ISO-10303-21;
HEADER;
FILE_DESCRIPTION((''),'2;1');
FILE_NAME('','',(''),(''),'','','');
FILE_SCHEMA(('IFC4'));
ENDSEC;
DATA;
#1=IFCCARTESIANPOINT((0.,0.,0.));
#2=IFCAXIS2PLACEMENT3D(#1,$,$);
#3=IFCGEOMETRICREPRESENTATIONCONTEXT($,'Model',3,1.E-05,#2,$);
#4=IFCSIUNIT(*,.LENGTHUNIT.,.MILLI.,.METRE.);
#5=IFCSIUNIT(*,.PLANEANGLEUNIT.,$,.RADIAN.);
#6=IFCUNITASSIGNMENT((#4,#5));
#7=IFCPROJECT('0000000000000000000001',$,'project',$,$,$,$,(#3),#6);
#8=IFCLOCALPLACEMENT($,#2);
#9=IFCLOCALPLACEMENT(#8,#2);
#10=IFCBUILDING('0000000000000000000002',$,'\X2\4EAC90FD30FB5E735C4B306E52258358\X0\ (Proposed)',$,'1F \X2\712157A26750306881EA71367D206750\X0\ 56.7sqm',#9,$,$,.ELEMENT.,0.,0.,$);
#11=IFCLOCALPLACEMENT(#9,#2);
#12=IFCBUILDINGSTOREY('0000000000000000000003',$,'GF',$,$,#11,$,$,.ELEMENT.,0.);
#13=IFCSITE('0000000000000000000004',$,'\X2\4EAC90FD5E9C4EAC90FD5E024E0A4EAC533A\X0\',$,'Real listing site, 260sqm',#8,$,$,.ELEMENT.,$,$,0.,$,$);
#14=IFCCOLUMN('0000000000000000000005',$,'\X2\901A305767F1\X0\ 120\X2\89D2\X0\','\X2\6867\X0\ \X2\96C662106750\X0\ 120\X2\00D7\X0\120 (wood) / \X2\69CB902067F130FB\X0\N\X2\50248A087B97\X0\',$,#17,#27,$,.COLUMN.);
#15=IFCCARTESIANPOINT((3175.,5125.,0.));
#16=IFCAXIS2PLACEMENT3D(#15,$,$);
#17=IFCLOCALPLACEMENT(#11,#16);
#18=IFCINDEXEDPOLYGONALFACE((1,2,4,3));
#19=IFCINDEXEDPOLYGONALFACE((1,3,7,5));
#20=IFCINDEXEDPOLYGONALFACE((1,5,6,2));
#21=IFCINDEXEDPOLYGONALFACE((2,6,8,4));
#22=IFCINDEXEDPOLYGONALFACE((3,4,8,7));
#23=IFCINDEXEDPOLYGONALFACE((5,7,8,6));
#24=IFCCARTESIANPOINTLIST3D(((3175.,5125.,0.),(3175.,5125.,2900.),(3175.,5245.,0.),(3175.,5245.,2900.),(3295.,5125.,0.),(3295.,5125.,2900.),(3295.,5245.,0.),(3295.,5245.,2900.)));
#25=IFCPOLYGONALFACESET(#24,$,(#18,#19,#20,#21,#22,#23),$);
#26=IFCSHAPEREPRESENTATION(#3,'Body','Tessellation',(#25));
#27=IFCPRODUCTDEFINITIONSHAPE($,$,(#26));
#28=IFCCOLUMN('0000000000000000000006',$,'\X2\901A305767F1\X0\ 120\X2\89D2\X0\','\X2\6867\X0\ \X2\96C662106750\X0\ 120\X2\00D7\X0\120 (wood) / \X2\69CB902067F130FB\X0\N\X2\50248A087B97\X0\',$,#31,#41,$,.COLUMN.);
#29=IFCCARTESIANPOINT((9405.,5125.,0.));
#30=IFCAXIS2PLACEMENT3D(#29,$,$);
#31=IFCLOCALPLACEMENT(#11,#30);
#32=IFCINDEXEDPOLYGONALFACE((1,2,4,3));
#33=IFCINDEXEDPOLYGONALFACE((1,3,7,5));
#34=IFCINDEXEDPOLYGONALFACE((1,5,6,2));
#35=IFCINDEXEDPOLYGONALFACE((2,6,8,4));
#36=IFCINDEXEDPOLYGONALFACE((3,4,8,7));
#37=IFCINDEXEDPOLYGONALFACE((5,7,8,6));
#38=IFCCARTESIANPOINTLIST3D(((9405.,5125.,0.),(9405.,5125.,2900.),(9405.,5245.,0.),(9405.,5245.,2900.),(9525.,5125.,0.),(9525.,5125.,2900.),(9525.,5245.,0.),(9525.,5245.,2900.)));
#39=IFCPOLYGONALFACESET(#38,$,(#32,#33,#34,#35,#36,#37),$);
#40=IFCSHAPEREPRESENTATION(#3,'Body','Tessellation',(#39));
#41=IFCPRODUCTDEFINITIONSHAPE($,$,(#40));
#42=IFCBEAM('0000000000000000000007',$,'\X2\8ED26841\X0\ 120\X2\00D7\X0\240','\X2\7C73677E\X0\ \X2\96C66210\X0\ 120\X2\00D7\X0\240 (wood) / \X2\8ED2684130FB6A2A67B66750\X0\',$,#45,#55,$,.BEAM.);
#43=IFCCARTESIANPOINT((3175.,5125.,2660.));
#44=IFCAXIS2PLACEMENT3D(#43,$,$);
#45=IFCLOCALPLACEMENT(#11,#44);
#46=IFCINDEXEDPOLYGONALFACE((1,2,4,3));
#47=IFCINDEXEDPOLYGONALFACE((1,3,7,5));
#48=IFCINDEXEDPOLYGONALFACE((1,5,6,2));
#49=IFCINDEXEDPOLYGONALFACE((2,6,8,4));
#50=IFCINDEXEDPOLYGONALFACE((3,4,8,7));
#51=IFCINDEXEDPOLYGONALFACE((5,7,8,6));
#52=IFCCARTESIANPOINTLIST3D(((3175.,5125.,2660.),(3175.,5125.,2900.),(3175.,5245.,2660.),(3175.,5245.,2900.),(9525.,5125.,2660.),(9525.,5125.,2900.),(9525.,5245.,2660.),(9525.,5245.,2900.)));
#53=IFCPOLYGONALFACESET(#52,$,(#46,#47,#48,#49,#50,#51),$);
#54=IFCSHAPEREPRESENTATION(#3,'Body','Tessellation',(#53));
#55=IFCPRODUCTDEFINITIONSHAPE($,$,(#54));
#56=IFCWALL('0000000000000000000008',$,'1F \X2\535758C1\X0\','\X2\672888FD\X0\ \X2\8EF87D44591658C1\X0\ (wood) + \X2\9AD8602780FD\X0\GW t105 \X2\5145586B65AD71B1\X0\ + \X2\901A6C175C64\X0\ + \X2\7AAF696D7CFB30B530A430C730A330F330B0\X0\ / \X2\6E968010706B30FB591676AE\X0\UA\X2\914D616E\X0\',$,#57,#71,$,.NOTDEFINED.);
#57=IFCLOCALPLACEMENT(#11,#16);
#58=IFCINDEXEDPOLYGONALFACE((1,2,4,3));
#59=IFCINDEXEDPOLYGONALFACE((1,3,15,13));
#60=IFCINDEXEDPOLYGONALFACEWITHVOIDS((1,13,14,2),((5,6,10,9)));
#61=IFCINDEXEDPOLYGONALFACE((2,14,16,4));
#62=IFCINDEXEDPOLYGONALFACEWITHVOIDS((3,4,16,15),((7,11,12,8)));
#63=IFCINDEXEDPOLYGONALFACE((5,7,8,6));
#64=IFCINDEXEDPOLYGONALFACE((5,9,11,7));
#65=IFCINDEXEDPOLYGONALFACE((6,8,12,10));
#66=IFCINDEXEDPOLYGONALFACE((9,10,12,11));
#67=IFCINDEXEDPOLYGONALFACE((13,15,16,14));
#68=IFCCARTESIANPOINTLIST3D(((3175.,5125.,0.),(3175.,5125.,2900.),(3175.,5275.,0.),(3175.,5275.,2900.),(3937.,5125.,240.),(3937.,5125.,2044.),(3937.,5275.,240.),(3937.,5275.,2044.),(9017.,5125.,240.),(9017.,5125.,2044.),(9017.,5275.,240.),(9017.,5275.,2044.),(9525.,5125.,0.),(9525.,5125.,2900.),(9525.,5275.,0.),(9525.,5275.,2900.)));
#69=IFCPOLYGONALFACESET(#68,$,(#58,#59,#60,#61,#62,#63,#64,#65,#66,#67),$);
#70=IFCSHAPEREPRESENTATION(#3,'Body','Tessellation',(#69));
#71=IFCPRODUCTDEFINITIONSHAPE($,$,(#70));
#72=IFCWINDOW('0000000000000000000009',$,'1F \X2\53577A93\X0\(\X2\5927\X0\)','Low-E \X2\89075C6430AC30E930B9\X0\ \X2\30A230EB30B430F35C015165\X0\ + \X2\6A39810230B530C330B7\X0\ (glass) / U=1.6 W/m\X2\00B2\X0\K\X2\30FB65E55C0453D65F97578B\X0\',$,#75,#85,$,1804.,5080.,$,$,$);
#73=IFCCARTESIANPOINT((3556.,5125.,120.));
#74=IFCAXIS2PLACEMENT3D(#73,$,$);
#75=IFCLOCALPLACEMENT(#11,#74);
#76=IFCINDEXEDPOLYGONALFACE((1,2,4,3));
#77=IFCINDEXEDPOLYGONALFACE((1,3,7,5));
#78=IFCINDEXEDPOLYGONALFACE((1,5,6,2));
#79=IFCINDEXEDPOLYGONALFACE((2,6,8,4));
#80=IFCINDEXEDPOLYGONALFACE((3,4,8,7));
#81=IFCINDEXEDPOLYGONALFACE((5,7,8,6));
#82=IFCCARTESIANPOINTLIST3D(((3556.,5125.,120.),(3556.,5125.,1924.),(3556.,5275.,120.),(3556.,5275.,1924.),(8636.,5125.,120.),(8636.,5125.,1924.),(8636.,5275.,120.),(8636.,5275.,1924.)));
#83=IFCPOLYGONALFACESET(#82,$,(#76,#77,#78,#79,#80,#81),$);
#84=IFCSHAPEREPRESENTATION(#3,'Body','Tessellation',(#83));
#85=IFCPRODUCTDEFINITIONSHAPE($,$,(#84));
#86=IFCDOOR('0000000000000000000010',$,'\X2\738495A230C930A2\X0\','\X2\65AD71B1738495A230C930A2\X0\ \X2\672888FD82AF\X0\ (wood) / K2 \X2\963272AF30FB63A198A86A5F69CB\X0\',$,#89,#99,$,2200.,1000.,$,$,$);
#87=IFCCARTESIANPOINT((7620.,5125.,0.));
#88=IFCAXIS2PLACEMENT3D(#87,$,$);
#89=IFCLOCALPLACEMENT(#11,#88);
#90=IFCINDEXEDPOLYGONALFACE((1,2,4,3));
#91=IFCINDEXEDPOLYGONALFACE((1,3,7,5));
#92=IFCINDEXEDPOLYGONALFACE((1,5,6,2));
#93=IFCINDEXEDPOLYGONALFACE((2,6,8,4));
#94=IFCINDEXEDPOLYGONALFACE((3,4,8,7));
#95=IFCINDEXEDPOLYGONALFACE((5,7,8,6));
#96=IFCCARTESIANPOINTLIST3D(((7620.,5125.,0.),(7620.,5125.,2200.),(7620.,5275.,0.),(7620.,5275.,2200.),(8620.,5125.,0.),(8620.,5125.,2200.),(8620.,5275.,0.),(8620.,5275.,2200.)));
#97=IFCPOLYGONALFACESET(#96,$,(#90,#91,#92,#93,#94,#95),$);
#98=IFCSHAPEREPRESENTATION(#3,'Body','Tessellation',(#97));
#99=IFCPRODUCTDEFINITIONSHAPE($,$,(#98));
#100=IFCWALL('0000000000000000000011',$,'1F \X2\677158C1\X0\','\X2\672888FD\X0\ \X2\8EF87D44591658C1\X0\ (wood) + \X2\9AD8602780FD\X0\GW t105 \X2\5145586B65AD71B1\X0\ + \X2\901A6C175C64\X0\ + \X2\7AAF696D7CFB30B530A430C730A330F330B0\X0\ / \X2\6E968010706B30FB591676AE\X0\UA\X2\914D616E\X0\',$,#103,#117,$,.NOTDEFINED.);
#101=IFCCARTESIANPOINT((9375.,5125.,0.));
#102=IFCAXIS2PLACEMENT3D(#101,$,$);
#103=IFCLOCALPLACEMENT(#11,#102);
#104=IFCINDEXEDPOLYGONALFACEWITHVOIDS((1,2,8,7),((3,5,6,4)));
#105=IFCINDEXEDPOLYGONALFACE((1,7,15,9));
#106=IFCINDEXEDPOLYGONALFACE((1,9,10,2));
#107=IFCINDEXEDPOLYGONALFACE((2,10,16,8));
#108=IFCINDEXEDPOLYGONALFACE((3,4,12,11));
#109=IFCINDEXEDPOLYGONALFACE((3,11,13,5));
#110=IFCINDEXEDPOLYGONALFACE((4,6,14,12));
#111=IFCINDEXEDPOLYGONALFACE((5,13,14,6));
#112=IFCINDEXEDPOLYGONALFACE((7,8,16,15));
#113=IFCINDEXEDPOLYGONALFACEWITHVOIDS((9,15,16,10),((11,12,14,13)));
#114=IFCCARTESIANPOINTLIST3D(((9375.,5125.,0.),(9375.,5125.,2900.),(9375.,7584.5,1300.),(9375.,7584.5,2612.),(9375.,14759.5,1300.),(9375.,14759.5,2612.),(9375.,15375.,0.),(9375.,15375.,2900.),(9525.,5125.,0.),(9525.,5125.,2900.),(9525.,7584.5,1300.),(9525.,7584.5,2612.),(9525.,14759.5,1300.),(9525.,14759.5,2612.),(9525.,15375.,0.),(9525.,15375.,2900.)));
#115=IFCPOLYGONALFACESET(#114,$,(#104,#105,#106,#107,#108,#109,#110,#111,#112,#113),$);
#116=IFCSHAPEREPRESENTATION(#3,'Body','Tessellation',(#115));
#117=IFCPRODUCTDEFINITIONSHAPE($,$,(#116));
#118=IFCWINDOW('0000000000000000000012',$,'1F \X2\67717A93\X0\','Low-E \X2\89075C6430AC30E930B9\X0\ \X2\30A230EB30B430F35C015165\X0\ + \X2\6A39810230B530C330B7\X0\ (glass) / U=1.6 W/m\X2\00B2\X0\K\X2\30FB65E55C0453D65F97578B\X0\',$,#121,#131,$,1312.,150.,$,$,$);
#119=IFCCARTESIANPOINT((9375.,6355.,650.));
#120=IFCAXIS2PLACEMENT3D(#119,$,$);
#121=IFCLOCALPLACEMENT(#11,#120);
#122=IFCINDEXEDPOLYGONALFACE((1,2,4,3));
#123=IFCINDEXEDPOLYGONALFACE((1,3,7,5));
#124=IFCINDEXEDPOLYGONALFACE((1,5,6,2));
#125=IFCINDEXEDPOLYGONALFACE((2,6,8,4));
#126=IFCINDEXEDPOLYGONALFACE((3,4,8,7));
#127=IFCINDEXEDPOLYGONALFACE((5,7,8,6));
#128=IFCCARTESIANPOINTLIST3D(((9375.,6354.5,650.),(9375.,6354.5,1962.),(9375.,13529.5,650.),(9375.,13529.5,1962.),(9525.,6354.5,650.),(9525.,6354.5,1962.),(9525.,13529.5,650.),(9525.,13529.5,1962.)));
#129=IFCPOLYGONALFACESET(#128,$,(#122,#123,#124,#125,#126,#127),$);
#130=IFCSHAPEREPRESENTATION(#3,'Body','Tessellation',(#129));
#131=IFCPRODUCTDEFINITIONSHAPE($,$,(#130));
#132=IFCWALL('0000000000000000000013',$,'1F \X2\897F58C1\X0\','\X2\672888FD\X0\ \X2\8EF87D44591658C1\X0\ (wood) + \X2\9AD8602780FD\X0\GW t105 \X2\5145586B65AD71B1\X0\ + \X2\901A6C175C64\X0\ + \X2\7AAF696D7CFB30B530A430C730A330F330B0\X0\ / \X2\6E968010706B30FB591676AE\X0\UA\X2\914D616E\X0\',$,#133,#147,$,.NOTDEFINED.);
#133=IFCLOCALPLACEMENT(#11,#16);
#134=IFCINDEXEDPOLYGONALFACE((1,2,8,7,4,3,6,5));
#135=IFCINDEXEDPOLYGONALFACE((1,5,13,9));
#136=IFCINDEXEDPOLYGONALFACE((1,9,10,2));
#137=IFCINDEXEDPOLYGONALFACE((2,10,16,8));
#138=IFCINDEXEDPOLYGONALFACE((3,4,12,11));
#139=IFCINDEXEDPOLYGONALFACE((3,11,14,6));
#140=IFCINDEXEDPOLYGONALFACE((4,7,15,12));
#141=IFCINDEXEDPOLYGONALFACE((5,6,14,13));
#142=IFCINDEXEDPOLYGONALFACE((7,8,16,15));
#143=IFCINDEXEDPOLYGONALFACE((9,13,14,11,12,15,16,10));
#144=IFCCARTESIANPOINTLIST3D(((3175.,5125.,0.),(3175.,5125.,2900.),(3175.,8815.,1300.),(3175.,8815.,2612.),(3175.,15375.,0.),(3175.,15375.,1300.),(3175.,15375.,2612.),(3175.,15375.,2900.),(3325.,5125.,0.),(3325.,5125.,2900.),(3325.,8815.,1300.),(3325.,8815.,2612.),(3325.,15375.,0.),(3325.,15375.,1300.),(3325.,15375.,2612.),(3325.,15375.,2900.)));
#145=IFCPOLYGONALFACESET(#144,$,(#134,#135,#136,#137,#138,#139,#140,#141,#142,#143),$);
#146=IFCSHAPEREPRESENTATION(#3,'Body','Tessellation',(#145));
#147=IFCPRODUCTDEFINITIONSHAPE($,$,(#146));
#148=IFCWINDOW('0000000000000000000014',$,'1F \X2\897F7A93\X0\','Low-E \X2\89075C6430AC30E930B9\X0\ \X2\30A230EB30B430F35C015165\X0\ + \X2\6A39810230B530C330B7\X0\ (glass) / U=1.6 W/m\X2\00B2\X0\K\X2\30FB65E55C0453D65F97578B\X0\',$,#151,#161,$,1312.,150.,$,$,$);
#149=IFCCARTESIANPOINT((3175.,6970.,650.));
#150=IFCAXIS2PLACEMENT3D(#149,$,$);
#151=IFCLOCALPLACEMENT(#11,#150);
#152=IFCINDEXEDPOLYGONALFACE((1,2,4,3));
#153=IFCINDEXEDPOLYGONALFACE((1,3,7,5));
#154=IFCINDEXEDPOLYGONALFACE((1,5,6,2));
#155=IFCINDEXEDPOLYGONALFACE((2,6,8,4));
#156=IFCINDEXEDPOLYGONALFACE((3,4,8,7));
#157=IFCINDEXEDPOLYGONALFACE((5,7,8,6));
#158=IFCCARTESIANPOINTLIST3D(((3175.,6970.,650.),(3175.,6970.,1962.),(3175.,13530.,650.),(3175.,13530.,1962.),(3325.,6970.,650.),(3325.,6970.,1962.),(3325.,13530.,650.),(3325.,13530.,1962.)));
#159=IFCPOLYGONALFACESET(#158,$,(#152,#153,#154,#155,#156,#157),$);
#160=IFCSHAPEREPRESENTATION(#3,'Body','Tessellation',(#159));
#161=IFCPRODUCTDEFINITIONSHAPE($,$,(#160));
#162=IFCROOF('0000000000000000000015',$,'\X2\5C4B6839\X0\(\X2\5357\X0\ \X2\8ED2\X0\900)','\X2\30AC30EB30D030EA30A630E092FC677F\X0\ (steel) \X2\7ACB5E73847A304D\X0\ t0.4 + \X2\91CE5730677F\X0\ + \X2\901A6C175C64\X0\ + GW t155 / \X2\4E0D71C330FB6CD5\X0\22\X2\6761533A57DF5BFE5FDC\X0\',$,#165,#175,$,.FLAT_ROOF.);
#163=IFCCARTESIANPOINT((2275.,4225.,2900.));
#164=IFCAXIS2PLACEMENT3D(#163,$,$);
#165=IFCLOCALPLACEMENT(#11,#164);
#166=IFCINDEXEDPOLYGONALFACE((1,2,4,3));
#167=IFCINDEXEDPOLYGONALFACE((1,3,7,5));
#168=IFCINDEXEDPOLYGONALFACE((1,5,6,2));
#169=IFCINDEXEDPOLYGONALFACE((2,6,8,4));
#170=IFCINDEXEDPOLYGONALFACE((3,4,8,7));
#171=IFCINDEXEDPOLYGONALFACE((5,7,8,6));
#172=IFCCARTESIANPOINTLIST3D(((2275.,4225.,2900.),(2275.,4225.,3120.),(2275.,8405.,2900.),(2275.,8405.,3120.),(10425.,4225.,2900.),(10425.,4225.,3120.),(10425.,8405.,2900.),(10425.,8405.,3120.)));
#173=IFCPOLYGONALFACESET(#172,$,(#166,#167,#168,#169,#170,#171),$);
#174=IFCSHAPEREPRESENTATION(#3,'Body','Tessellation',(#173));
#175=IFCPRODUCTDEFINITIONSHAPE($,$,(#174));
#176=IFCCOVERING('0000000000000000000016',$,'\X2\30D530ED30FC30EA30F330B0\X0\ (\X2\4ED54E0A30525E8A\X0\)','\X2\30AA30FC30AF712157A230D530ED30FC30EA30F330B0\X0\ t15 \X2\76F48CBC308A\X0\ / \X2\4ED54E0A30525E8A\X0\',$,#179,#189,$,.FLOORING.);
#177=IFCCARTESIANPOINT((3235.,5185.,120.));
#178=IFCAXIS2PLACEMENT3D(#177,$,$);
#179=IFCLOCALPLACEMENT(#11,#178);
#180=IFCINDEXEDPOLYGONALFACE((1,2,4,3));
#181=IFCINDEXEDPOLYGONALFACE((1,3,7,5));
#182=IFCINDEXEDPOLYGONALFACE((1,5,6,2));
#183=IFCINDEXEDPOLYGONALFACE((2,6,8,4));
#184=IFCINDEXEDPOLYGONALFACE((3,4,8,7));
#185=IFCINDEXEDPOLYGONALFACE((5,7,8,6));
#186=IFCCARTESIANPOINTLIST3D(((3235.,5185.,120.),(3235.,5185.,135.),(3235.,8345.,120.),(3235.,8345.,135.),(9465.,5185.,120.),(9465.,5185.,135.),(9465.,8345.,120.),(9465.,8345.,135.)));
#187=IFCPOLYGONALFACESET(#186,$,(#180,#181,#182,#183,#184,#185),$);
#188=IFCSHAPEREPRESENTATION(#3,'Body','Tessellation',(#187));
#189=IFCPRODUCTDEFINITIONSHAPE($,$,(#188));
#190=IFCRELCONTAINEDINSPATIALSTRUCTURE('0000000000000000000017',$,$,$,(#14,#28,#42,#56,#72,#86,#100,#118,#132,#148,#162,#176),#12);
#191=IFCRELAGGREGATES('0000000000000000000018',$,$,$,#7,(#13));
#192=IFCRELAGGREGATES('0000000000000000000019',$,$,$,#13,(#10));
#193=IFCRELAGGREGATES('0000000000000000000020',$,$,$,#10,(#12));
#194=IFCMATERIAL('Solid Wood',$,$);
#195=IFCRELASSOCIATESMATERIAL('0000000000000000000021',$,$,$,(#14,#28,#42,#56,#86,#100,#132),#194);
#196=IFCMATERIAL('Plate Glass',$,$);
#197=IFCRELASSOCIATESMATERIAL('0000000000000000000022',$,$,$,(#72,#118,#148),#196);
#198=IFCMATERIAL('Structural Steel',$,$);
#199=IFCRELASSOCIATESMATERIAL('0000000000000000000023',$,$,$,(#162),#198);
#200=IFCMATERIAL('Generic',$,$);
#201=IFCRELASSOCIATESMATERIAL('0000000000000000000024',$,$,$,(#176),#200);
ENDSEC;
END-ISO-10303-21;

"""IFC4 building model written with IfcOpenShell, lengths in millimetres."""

from ifc_helpers import new_model, si_unit, frame, frame_2d, origin, place, context, project, spatial, rectangle, extrude, material, element, fill, save


model = new_model("IFC4")

# Units and contexts
model_context = context("Model", 3, precision=1e-05, world=origin())
ifc_project = project(units=[si_unit("LENGTHUNIT", "METRE", prefix="MILLI"), si_unit("PLANEANGLEUNIT", "RADIAN")], contexts=[model_context])

# Site, building, storey
site_placement = place(None, origin())
site = spatial("IfcSite", under=ifc_project, at=site_placement, Name="京都府京都市上京区", ObjectType="Real listing site, 260sqm", CompositionType="ELEMENT", RefElevation=0.0)
building_placement = place(site_placement, origin())
building = spatial("IfcBuilding", under=site, at=building_placement, Name="京都・平屋の別荘 (Proposed)", ObjectType="1F 無垢材と自然素材 56.7sqm", CompositionType="ELEMENT", ElevationOfRefHeight=0.0, ElevationOfTerrain=0.0)
storey_placement = place(building_placement, origin())
storey = spatial("IfcBuildingStorey", under=building, at=storey_placement, Name="GF", CompositionType="ELEMENT", Elevation=0.0)

# Columns
ifc_material_1 = material(Name="Solid Wood")
column_1_placement = place(storey_placement, frame((3175.0, 5125.0, 0.0)))
element("IfcColumn", 1, at=column_1_placement, inside=storey, material=ifc_material_1, Name="通し柱 120角", Description="桧 集成材 120×120 (wood) / 構造柱・N値計算", PredefinedType="COLUMN", context=model_context, shape_type="SweptSolid", body=[
    extrude(rectangle(XDim=120.0, YDim=120.0, at=frame_2d((60.0, 60.0))), frame((3175.0, 5125.0, 0.0)), (0.0, 0.0, 1.0), 2900.0),
])
column_2_placement = place(storey_placement, frame((9405.0, 5125.0, 0.0)))
element("IfcColumn", 2, at=column_2_placement, inside=storey, material=ifc_material_1, Name="通し柱 120角", Description="桧 集成材 120×120 (wood) / 構造柱・N値計算", PredefinedType="COLUMN", context=model_context, shape_type="SweptSolid", body=[
    extrude(rectangle(XDim=120.0, YDim=120.0, at=frame_2d((60.0, 60.0))), frame((9405.0, 5125.0, 0.0)), (0.0, 0.0, 1.0), 2900.0),
])

# Beam
beam_1_placement = place(storey_placement, frame((3175.0, 5125.0, 2660.0)))
element("IfcBeam", 3, at=beam_1_placement, inside=storey, material=ifc_material_1, Name="軒桁 120×240", Description="米松 集成 120×240 (wood) / 軒桁・横架材", PredefinedType="BEAM", context=model_context, shape_type="SweptSolid", body=[
    extrude(rectangle(XDim=6350.0, YDim=120.0, at=frame_2d((3175.0, 60.0))), frame((3175.0, 5125.0, 2660.0)), (0.0, 0.0, 1.0), 240.0),
])

# Wall, openings, window, door
wall_1_placement = place(storey_placement, frame((3175.0, 5125.0, 0.0)))
wall_1 = element("IfcWall", 4, at=wall_1_placement, inside=storey, material=ifc_material_1, Name="1F 南壁", Description="木製 軸組外壁 (wood) + 高性能GW t105 充填断熱 + 通気層 + 窯業系サイディング / 準耐火・外皮UA配慮", PredefinedType="NOTDEFINED", context=model_context, shape_type="SweptSolid", body=[
    extrude(rectangle(XDim=6350.0, YDim=150.0, at=frame_2d((3175.0, 75.0))), frame((3175.0, 5125.0, 0.0)), (0.0, 0.0, 1.0), 2900.0),
])
opening_1_placement = place(storey_placement, frame((3556.0, 5125.0, 120.0)))
opening_1 = element("IfcOpeningElement", 5, at=opening_1_placement, cuts=wall_1, PredefinedType="NOTDEFINED", context=model_context, shape_type="SweptSolid", body=[
    extrude(rectangle(XDim=5080.0, YDim=150.0, at=frame_2d((2540.0, 75.0))), frame((3556.0, 5125.0, 120.0)), (0.0, 0.0, 1.0), 1804.0),
])
opening_2_placement = place(storey_placement, frame((7620.0, 5125.0, 0.0)))
opening_2 = element("IfcOpeningElement", 6, at=opening_2_placement, cuts=wall_1, PredefinedType="NOTDEFINED", context=model_context, shape_type="SweptSolid", body=[
    extrude(rectangle(XDim=1000.0, YDim=150.0, at=frame_2d((500.0, 75.0))), frame((7620.0, 5125.0, 0.0)), (0.0, 0.0, 1.0), 2200.0),
])
ifc_material_2 = material(Name="Plate Glass")
window_1_placement = place(storey_placement, frame((3556.0, 5125.0, 120.0)))
window_1 = element("IfcWindow", 7, at=window_1_placement, inside=storey, material=ifc_material_2, Name="1F 南窓(大)", Description="Low-E 複層ガラス アルゴン封入 + 樹脂サッシ (glass) / U=1.6 W/m²K・日射取得型", OverallHeight=1804.0, OverallWidth=5080.0, context=model_context, shape_type="SweptSolid", body=[
    extrude(rectangle(XDim=5080.0, YDim=150.0, at=frame_2d((2540.0, 75.0))), frame((3556.0, 5125.0, 120.0)), (0.0, 0.0, 1.0), 1804.0),
])
fill(opening_1, window_1)
door_placement = place(storey_placement, frame((7620.0, 5125.0, 0.0)))
door = element("IfcDoor", 8, at=door_placement, inside=storey, material=ifc_material_1, Name="玄関ドア", Description="断熱玄関ドア 木製芯 (wood) / K2 防犯・採風機構", OverallHeight=2200.0, OverallWidth=1000.0, context=model_context, shape_type="SweptSolid", body=[
    extrude(rectangle(XDim=1000.0, YDim=150.0, at=frame_2d((500.0, 75.0))), frame((7620.0, 5125.0, 0.0)), (0.0, 0.0, 1.0), 2200.0),
])
fill(opening_2, door)

# Walls, openings, windows
wall_2_placement = place(storey_placement, frame((9375.0, 5125.0, 0.0)))
wall_2 = element("IfcWall", 9, at=wall_2_placement, inside=storey, material=ifc_material_1, Name="1F 東壁", Description="木製 軸組外壁 (wood) + 高性能GW t105 充填断熱 + 通気層 + 窯業系サイディング / 準耐火・外皮UA配慮", PredefinedType="NOTDEFINED", context=model_context, shape_type="SweptSolid", body=[
    extrude(rectangle(XDim=150.0, YDim=10250.0, at=frame_2d((75.0, 5125.0))), frame((9375.0, 5125.0, 0.0)), (0.0, 0.0, 1.0), 2900.0),
])
opening_3_placement = place(storey_placement, frame((9375.0, 6355.0, 650.0)))
opening_3 = element("IfcOpeningElement", 10, at=opening_3_placement, cuts=wall_2, PredefinedType="NOTDEFINED", context=model_context, shape_type="SweptSolid", body=[
    extrude(rectangle(XDim=150.0, YDim=7175.0, at=frame_2d((75.0, 3587.0))), frame((9375.0, 6355.0, 650.0)), (0.0, 0.0, 1.0), 1312.0),
])
window_2_placement = place(storey_placement, frame((9375.0, 6355.0, 650.0)))
window_2 = element("IfcWindow", 11, at=window_2_placement, inside=storey, material=ifc_material_2, Name="1F 東窓", Description="Low-E 複層ガラス アルゴン封入 + 樹脂サッシ (glass) / U=1.6 W/m²K・日射取得型", OverallHeight=1312.0, OverallWidth=150.0, context=model_context, shape_type="SweptSolid", body=[
    extrude(rectangle(XDim=150.0, YDim=7175.0, at=frame_2d((75.0, 3587.0))), frame((9375.0, 6355.0, 650.0)), (0.0, 0.0, 1.0), 1312.0),
])
fill(opening_3, window_2)
wall_3_placement = place(storey_placement, frame((3175.0, 5125.0, 0.0)))
wall_3 = element("IfcWall", 12, at=wall_3_placement, inside=storey, material=ifc_material_1, Name="1F 西壁", Description="木製 軸組外壁 (wood) + 高性能GW t105 充填断熱 + 通気層 + 窯業系サイディング / 準耐火・外皮UA配慮", PredefinedType="NOTDEFINED", context=model_context, shape_type="SweptSolid", body=[
    extrude(rectangle(XDim=150.0, YDim=10250.0, at=frame_2d((75.0, 5125.0))), frame((3175.0, 5125.0, 0.0)), (0.0, 0.0, 1.0), 2900.0),
])
opening_4_placement = place(storey_placement, frame((3175.0, 6970.0, 650.0)))
opening_4 = element("IfcOpeningElement", 13, at=opening_4_placement, cuts=wall_3, PredefinedType="NOTDEFINED", context=model_context, shape_type="SweptSolid", body=[
    extrude(rectangle(XDim=150.0, YDim=6560.0, at=frame_2d((75.0, 3280.0))), frame((3175.0, 6970.0, 650.0)), (0.0, 0.0, 1.0), 1312.0),
])
window_3_placement = place(storey_placement, frame((3175.0, 6970.0, 650.0)))
window_3 = element("IfcWindow", 14, at=window_3_placement, inside=storey, material=ifc_material_2, Name="1F 西窓", Description="Low-E 複層ガラス アルゴン封入 + 樹脂サッシ (glass) / U=1.6 W/m²K・日射取得型", OverallHeight=1312.0, OverallWidth=150.0, context=model_context, shape_type="SweptSolid", body=[
    extrude(rectangle(XDim=150.0, YDim=6560.0, at=frame_2d((75.0, 3280.0))), frame((3175.0, 6970.0, 650.0)), (0.0, 0.0, 1.0), 1312.0),
])
fill(opening_4, window_3)

# Roof
ifc_material_3 = material(Name="Structural Steel")
roof_placement = place(storey_placement, frame((2275.0, 4225.0, 2900.0)))
element("IfcRoof", 15, at=roof_placement, inside=storey, material=ifc_material_3, Name="屋根(南 軒900)", Description="ガルバリウム鋼板 (steel) 立平葺き t0.4 + 野地板 + 通気層 + GW t155 / 不燃・法22条区域対応", PredefinedType="FLAT_ROOF", context=model_context, shape_type="SweptSolid", body=[
    extrude(rectangle(XDim=8150.0, YDim=4180.0, at=frame_2d((4075.0, 2090.0))), frame((2275.0, 4225.0, 2900.0)), (0.0, 0.0, 1.0), 220.0),
])

# Covering
ifc_material_4 = material(Name="Generic")
covering_1_placement = place(storey_placement, frame((3235.0, 5185.0, 120.0)))
element("IfcCovering", 16, at=covering_1_placement, inside=storey, material=ifc_material_4, Name="フローリング (仕上げ床)", Description="オーク無垢フローリング t15 直貼り / 仕上げ床", PredefinedType="FLOORING", context=model_context, shape_type="SweptSolid", body=[
    extrude(rectangle(XDim=6230.0, YDim=3160.0, at=frame_2d((3115.0, 1580.0))), frame((3235.0, 5185.0, 120.0)), (0.0, 0.0, 1.0), 15.0),
])

save(model, "model.ifc")
